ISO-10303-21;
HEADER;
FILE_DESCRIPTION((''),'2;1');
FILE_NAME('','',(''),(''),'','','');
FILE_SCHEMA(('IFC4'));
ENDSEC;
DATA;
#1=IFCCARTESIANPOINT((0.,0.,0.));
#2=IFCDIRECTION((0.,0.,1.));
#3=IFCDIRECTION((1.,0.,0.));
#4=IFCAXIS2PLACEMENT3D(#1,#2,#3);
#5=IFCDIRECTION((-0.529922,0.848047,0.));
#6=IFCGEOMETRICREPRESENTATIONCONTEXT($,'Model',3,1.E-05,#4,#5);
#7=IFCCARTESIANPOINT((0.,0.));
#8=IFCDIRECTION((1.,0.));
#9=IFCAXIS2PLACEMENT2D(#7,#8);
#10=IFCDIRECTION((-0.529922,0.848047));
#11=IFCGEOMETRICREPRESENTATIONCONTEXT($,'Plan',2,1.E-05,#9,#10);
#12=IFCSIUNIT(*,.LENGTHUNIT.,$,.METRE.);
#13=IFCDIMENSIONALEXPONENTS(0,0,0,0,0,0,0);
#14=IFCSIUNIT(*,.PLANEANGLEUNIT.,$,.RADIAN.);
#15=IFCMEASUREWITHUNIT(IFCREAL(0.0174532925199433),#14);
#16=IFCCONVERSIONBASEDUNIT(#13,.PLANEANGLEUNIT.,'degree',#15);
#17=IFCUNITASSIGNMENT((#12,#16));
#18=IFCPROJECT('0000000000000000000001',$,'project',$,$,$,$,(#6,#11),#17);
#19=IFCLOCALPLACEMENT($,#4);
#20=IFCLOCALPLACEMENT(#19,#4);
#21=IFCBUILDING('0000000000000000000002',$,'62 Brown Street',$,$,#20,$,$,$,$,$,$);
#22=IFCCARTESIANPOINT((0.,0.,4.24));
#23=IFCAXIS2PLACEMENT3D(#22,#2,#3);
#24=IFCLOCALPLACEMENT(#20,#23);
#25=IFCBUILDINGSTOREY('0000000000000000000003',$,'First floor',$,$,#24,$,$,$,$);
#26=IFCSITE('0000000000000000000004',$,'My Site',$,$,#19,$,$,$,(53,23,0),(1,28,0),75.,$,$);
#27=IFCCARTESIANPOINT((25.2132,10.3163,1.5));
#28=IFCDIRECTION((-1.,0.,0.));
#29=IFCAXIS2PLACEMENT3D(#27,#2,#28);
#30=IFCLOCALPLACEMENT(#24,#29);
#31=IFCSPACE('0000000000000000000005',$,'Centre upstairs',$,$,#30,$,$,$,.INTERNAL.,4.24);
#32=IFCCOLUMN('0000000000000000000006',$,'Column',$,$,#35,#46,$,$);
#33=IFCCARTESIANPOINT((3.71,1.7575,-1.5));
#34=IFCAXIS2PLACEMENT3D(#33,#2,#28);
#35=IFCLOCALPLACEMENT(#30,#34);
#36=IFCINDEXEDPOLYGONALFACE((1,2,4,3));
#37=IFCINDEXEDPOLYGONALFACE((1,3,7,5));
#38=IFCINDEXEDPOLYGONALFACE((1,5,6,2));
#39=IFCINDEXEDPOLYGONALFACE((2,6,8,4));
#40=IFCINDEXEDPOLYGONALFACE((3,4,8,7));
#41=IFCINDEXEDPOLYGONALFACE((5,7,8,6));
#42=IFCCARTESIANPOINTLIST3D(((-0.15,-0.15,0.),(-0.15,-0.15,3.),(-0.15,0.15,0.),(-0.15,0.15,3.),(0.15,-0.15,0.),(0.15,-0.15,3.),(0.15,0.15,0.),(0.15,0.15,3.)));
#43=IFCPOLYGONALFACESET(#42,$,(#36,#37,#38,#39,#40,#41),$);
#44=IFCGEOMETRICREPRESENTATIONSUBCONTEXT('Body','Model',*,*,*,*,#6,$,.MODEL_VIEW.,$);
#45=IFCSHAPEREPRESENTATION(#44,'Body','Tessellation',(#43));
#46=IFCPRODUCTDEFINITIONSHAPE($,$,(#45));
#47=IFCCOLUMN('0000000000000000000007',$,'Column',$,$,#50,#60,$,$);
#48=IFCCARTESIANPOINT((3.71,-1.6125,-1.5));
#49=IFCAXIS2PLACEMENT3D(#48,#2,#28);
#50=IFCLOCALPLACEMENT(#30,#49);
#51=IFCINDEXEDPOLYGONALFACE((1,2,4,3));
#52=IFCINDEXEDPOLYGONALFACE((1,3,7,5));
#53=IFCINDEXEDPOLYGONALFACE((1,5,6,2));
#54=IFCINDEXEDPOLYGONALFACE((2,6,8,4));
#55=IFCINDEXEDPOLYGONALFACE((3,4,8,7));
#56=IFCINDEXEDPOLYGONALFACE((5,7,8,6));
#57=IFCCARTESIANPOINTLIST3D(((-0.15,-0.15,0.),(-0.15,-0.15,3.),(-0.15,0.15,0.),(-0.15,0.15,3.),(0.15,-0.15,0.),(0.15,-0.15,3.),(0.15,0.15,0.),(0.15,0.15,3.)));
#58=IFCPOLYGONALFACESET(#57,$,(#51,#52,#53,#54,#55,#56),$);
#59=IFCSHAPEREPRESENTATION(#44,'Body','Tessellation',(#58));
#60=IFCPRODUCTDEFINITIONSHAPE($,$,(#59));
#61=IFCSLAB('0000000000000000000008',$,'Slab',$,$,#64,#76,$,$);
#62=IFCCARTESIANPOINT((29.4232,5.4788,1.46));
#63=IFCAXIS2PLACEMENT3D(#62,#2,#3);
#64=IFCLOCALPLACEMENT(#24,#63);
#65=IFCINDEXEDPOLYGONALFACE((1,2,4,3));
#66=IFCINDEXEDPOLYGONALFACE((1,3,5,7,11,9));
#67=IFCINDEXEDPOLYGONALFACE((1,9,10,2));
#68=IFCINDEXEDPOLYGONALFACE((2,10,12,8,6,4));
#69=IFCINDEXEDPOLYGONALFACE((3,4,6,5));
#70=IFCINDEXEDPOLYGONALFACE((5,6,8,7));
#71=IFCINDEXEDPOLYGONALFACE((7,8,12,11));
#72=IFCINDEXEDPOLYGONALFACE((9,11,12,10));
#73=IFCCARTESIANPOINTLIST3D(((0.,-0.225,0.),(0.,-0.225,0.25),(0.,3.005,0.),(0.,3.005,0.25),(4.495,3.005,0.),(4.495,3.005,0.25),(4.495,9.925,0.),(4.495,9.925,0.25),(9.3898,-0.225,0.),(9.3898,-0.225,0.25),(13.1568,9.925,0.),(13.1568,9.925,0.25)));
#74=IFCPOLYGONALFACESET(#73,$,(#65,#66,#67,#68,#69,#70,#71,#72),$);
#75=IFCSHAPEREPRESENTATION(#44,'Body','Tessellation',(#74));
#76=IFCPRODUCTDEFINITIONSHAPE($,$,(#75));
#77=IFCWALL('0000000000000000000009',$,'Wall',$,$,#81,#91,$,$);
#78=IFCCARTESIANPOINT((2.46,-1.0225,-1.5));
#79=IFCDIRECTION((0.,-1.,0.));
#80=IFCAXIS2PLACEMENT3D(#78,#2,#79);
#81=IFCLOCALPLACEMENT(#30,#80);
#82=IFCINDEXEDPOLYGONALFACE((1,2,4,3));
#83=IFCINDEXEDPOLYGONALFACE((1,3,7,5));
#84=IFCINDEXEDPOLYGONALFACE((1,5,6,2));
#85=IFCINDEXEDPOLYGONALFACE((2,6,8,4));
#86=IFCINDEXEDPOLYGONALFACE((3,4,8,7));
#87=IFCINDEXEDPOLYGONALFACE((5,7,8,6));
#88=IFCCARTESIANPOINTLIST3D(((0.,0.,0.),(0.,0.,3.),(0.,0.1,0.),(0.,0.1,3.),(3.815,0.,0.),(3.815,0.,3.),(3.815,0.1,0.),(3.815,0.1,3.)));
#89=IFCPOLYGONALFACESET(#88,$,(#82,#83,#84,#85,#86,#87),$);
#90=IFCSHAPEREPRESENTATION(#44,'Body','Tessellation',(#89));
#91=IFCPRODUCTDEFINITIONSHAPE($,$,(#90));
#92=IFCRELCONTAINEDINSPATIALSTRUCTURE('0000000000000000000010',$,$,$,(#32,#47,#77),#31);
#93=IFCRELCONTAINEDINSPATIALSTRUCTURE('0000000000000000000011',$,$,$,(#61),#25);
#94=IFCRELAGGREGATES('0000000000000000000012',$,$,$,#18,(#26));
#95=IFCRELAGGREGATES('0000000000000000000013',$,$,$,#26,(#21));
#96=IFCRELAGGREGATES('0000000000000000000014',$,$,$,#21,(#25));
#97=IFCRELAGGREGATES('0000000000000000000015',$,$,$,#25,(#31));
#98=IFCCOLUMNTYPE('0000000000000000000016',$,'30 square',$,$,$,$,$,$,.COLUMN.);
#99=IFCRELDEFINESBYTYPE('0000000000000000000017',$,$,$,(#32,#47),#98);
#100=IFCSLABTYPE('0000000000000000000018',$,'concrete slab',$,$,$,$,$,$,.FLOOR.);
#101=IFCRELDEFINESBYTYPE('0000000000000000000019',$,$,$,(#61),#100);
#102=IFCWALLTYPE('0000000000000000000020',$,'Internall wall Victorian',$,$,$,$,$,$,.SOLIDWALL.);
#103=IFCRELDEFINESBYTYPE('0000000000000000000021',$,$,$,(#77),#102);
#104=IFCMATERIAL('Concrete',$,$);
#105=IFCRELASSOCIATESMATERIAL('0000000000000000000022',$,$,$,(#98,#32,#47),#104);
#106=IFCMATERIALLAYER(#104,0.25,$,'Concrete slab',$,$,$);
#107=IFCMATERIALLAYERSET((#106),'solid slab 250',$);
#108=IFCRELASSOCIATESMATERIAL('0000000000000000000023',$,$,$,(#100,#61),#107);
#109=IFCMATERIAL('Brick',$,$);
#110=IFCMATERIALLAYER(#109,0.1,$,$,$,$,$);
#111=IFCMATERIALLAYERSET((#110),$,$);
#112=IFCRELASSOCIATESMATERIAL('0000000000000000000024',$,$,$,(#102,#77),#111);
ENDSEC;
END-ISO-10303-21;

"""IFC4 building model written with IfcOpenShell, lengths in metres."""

from ifc_helpers import new_model, entity, si_unit, converted_unit, direction, frame, origin_with_axes, origin_2d_with_axis, place, context, subcontext, project, spatial, line, indexed_curve, rectangle, outline, extrude, material, layer, layer_set, layer_usage, material_profile, profile_set, profile_usage, type_object, element, save


model = new_model("IFC4")

# Units and contexts
model_context = context("Model", 3, precision=1e-05, world=origin_with_axes(), true_north=direction((-0.529922, 0.848047, 0.0)))
plan_context = context("Plan", 2, precision=1e-05, world=origin_2d_with_axis(), true_north=direction((-0.529922, 0.848047)))
body_context_1 = subcontext(model_context, "Body", "Model", "MODEL_VIEW")
ifc_project = project(units=[si_unit("LENGTHUNIT", "METRE"), converted_unit("PLANEANGLEUNIT", "degree", entity("IfcReal", 0.0174532925199433), si_unit("PLANEANGLEUNIT", "RADIAN"), dimensions=[0, 0, 0, 0, 0, 0, 0])], contexts=[model_context, plan_context])

# Site, building, storey, space
site_placement = place(None, origin_with_axes())
site = spatial("IfcSite", under=ifc_project, at=site_placement, Name="My Site", RefLatitude=(53, 23, 0), RefLongitude=(1, 28, 0), RefElevation=75.0)
building_placement = place(site_placement, origin_with_axes())
building = spatial("IfcBuilding", under=site, at=building_placement, Name="62 Brown Street")
storey_placement = place(building_placement, frame((0.0, 0.0, 4.24), z_axis=(0.0, 0.0, 1.0), x_axis=(1.0, 0.0, 0.0)))
storey = spatial("IfcBuildingStorey", under=building, at=storey_placement, Name="First floor")
space_placement = place(storey_placement, frame((25.2132, 10.3163, 1.5), z_axis=(0.0, 0.0, 1.0), x_axis=(-1.0, 0.0, 0.0)))
space = spatial("IfcSpace", under=storey, at=space_placement, Name="Centre upstairs", PredefinedType="INTERNAL", ElevationWithFlooring=4.24)

# Columns
ifc_material_1 = material(Name="Concrete")
ifc_material_profile_1 = material_profile(ifc_material_1, rectangle(XDim=0.3, YDim=0.3))
ifc_profile_set_1 = profile_set([ifc_material_profile_1])
ifc_profile_usage_1 = profile_usage(ifc_profile_set_1, cardinal=5)
column_type = type_object("IfcColumnType", Name="30 square", PredefinedType="COLUMN", material=ifc_profile_set_1)
column_1_placement = place(space_placement, frame((3.71, 1.7575, -1.5), z_axis=(0.0, 0.0, 1.0), x_axis=(-1.0, 0.0, 0.0)))
element("IfcColumn", 1, at=column_1_placement, inside=space, type_object=column_type, material=ifc_profile_usage_1, Name="Column", context=body_context_1, shape_type="SweptSolid", body=[
    extrude(rectangle(XDim=0.3, YDim=0.3), origin_with_axes(), (0.0, 0.0, 1.0), 3.0),
])
ifc_profile_usage_2 = profile_usage(ifc_profile_set_1, cardinal=5)
column_2_placement = place(space_placement, frame((3.71, -1.6125, -1.5), z_axis=(0.0, 0.0, 1.0), x_axis=(-1.0, 0.0, 0.0)))
element("IfcColumn", 2, at=column_2_placement, inside=space, type_object=column_type, material=ifc_profile_usage_2, Name="Column", context=body_context_1, shape_type="SweptSolid", body=[
    extrude(rectangle(XDim=0.3, YDim=0.3), origin_with_axes(), (0.0, 0.0, 1.0), 3.0),
])

# Slab
ifc_layer_1 = layer(ifc_material_1, 0.25, Name="Concrete slab")
ifc_layer_set_1 = layer_set([ifc_layer_1], Name="solid slab 250")
slab_type = type_object("IfcSlabType", Name="concrete slab", PredefinedType="FLOOR", material=ifc_layer_set_1)
ifc_layer_usage_1 = layer_usage(ifc_layer_set_1, "AXIS3", "POSITIVE", 0.0)
slab_1_placement = place(storey_placement, frame((29.4232, 5.4788, 1.46), z_axis=(0.0, 0.0, 1.0), x_axis=(1.0, 0.0, 0.0)))
element("IfcSlab", 3, at=slab_1_placement, inside=storey, type_object=slab_type, material=ifc_layer_usage_1, Name="Slab", context=body_context_1, shape_type="SweptSolid", body=[
    extrude(outline(indexed_curve([(0.0, 3.005), (0.0, -0.225), (9.3898, -0.225), (13.1568, 9.925), (4.495, 9.925), (4.495, 3.005)], segments=[line(4, 3), line(3, 2), line(2, 1), line(1, 6), line(6, 5), line(5, 4)], self_intersect=False)), None, (0.0, 0.0, 1.0), 0.25),
])

# Shared definitions
ifc_material_2 = material(Name="Brick")
ifc_layer_2 = layer(ifc_material_2, 0.1)
ifc_layer_set_2 = layer_set([ifc_layer_2])
wall_type_1 = type_object("IfcWallType", Name="Internall wall Victorian", PredefinedType="SOLIDWALL", material=ifc_layer_set_2)

# Wall
ifc_layer_usage_2 = layer_usage(ifc_layer_set_2, "AXIS2", "POSITIVE", 0.0)
wall_1_placement = place(space_placement, frame((2.46, -1.0225, -1.5), z_axis=(0.0, 0.0, 1.0), x_axis=(0.0, -1.0, 0.0)))
element("IfcWall", 4, at=wall_1_placement, inside=space, type_object=wall_type_1, material=ifc_layer_usage_2, Name="Wall", context=body_context_1, shape_type="SweptSolid", body=[
    extrude(outline(indexed_curve([(0.0, 0.0), (0.0, 0.1), (3.815, 0.1), (3.815, 0.0), (0.0, 0.0)], self_intersect=False)), origin_with_axes(), (0.0, 0.0, 1.0), 3.0),
])

save(model, "model.ifc")
